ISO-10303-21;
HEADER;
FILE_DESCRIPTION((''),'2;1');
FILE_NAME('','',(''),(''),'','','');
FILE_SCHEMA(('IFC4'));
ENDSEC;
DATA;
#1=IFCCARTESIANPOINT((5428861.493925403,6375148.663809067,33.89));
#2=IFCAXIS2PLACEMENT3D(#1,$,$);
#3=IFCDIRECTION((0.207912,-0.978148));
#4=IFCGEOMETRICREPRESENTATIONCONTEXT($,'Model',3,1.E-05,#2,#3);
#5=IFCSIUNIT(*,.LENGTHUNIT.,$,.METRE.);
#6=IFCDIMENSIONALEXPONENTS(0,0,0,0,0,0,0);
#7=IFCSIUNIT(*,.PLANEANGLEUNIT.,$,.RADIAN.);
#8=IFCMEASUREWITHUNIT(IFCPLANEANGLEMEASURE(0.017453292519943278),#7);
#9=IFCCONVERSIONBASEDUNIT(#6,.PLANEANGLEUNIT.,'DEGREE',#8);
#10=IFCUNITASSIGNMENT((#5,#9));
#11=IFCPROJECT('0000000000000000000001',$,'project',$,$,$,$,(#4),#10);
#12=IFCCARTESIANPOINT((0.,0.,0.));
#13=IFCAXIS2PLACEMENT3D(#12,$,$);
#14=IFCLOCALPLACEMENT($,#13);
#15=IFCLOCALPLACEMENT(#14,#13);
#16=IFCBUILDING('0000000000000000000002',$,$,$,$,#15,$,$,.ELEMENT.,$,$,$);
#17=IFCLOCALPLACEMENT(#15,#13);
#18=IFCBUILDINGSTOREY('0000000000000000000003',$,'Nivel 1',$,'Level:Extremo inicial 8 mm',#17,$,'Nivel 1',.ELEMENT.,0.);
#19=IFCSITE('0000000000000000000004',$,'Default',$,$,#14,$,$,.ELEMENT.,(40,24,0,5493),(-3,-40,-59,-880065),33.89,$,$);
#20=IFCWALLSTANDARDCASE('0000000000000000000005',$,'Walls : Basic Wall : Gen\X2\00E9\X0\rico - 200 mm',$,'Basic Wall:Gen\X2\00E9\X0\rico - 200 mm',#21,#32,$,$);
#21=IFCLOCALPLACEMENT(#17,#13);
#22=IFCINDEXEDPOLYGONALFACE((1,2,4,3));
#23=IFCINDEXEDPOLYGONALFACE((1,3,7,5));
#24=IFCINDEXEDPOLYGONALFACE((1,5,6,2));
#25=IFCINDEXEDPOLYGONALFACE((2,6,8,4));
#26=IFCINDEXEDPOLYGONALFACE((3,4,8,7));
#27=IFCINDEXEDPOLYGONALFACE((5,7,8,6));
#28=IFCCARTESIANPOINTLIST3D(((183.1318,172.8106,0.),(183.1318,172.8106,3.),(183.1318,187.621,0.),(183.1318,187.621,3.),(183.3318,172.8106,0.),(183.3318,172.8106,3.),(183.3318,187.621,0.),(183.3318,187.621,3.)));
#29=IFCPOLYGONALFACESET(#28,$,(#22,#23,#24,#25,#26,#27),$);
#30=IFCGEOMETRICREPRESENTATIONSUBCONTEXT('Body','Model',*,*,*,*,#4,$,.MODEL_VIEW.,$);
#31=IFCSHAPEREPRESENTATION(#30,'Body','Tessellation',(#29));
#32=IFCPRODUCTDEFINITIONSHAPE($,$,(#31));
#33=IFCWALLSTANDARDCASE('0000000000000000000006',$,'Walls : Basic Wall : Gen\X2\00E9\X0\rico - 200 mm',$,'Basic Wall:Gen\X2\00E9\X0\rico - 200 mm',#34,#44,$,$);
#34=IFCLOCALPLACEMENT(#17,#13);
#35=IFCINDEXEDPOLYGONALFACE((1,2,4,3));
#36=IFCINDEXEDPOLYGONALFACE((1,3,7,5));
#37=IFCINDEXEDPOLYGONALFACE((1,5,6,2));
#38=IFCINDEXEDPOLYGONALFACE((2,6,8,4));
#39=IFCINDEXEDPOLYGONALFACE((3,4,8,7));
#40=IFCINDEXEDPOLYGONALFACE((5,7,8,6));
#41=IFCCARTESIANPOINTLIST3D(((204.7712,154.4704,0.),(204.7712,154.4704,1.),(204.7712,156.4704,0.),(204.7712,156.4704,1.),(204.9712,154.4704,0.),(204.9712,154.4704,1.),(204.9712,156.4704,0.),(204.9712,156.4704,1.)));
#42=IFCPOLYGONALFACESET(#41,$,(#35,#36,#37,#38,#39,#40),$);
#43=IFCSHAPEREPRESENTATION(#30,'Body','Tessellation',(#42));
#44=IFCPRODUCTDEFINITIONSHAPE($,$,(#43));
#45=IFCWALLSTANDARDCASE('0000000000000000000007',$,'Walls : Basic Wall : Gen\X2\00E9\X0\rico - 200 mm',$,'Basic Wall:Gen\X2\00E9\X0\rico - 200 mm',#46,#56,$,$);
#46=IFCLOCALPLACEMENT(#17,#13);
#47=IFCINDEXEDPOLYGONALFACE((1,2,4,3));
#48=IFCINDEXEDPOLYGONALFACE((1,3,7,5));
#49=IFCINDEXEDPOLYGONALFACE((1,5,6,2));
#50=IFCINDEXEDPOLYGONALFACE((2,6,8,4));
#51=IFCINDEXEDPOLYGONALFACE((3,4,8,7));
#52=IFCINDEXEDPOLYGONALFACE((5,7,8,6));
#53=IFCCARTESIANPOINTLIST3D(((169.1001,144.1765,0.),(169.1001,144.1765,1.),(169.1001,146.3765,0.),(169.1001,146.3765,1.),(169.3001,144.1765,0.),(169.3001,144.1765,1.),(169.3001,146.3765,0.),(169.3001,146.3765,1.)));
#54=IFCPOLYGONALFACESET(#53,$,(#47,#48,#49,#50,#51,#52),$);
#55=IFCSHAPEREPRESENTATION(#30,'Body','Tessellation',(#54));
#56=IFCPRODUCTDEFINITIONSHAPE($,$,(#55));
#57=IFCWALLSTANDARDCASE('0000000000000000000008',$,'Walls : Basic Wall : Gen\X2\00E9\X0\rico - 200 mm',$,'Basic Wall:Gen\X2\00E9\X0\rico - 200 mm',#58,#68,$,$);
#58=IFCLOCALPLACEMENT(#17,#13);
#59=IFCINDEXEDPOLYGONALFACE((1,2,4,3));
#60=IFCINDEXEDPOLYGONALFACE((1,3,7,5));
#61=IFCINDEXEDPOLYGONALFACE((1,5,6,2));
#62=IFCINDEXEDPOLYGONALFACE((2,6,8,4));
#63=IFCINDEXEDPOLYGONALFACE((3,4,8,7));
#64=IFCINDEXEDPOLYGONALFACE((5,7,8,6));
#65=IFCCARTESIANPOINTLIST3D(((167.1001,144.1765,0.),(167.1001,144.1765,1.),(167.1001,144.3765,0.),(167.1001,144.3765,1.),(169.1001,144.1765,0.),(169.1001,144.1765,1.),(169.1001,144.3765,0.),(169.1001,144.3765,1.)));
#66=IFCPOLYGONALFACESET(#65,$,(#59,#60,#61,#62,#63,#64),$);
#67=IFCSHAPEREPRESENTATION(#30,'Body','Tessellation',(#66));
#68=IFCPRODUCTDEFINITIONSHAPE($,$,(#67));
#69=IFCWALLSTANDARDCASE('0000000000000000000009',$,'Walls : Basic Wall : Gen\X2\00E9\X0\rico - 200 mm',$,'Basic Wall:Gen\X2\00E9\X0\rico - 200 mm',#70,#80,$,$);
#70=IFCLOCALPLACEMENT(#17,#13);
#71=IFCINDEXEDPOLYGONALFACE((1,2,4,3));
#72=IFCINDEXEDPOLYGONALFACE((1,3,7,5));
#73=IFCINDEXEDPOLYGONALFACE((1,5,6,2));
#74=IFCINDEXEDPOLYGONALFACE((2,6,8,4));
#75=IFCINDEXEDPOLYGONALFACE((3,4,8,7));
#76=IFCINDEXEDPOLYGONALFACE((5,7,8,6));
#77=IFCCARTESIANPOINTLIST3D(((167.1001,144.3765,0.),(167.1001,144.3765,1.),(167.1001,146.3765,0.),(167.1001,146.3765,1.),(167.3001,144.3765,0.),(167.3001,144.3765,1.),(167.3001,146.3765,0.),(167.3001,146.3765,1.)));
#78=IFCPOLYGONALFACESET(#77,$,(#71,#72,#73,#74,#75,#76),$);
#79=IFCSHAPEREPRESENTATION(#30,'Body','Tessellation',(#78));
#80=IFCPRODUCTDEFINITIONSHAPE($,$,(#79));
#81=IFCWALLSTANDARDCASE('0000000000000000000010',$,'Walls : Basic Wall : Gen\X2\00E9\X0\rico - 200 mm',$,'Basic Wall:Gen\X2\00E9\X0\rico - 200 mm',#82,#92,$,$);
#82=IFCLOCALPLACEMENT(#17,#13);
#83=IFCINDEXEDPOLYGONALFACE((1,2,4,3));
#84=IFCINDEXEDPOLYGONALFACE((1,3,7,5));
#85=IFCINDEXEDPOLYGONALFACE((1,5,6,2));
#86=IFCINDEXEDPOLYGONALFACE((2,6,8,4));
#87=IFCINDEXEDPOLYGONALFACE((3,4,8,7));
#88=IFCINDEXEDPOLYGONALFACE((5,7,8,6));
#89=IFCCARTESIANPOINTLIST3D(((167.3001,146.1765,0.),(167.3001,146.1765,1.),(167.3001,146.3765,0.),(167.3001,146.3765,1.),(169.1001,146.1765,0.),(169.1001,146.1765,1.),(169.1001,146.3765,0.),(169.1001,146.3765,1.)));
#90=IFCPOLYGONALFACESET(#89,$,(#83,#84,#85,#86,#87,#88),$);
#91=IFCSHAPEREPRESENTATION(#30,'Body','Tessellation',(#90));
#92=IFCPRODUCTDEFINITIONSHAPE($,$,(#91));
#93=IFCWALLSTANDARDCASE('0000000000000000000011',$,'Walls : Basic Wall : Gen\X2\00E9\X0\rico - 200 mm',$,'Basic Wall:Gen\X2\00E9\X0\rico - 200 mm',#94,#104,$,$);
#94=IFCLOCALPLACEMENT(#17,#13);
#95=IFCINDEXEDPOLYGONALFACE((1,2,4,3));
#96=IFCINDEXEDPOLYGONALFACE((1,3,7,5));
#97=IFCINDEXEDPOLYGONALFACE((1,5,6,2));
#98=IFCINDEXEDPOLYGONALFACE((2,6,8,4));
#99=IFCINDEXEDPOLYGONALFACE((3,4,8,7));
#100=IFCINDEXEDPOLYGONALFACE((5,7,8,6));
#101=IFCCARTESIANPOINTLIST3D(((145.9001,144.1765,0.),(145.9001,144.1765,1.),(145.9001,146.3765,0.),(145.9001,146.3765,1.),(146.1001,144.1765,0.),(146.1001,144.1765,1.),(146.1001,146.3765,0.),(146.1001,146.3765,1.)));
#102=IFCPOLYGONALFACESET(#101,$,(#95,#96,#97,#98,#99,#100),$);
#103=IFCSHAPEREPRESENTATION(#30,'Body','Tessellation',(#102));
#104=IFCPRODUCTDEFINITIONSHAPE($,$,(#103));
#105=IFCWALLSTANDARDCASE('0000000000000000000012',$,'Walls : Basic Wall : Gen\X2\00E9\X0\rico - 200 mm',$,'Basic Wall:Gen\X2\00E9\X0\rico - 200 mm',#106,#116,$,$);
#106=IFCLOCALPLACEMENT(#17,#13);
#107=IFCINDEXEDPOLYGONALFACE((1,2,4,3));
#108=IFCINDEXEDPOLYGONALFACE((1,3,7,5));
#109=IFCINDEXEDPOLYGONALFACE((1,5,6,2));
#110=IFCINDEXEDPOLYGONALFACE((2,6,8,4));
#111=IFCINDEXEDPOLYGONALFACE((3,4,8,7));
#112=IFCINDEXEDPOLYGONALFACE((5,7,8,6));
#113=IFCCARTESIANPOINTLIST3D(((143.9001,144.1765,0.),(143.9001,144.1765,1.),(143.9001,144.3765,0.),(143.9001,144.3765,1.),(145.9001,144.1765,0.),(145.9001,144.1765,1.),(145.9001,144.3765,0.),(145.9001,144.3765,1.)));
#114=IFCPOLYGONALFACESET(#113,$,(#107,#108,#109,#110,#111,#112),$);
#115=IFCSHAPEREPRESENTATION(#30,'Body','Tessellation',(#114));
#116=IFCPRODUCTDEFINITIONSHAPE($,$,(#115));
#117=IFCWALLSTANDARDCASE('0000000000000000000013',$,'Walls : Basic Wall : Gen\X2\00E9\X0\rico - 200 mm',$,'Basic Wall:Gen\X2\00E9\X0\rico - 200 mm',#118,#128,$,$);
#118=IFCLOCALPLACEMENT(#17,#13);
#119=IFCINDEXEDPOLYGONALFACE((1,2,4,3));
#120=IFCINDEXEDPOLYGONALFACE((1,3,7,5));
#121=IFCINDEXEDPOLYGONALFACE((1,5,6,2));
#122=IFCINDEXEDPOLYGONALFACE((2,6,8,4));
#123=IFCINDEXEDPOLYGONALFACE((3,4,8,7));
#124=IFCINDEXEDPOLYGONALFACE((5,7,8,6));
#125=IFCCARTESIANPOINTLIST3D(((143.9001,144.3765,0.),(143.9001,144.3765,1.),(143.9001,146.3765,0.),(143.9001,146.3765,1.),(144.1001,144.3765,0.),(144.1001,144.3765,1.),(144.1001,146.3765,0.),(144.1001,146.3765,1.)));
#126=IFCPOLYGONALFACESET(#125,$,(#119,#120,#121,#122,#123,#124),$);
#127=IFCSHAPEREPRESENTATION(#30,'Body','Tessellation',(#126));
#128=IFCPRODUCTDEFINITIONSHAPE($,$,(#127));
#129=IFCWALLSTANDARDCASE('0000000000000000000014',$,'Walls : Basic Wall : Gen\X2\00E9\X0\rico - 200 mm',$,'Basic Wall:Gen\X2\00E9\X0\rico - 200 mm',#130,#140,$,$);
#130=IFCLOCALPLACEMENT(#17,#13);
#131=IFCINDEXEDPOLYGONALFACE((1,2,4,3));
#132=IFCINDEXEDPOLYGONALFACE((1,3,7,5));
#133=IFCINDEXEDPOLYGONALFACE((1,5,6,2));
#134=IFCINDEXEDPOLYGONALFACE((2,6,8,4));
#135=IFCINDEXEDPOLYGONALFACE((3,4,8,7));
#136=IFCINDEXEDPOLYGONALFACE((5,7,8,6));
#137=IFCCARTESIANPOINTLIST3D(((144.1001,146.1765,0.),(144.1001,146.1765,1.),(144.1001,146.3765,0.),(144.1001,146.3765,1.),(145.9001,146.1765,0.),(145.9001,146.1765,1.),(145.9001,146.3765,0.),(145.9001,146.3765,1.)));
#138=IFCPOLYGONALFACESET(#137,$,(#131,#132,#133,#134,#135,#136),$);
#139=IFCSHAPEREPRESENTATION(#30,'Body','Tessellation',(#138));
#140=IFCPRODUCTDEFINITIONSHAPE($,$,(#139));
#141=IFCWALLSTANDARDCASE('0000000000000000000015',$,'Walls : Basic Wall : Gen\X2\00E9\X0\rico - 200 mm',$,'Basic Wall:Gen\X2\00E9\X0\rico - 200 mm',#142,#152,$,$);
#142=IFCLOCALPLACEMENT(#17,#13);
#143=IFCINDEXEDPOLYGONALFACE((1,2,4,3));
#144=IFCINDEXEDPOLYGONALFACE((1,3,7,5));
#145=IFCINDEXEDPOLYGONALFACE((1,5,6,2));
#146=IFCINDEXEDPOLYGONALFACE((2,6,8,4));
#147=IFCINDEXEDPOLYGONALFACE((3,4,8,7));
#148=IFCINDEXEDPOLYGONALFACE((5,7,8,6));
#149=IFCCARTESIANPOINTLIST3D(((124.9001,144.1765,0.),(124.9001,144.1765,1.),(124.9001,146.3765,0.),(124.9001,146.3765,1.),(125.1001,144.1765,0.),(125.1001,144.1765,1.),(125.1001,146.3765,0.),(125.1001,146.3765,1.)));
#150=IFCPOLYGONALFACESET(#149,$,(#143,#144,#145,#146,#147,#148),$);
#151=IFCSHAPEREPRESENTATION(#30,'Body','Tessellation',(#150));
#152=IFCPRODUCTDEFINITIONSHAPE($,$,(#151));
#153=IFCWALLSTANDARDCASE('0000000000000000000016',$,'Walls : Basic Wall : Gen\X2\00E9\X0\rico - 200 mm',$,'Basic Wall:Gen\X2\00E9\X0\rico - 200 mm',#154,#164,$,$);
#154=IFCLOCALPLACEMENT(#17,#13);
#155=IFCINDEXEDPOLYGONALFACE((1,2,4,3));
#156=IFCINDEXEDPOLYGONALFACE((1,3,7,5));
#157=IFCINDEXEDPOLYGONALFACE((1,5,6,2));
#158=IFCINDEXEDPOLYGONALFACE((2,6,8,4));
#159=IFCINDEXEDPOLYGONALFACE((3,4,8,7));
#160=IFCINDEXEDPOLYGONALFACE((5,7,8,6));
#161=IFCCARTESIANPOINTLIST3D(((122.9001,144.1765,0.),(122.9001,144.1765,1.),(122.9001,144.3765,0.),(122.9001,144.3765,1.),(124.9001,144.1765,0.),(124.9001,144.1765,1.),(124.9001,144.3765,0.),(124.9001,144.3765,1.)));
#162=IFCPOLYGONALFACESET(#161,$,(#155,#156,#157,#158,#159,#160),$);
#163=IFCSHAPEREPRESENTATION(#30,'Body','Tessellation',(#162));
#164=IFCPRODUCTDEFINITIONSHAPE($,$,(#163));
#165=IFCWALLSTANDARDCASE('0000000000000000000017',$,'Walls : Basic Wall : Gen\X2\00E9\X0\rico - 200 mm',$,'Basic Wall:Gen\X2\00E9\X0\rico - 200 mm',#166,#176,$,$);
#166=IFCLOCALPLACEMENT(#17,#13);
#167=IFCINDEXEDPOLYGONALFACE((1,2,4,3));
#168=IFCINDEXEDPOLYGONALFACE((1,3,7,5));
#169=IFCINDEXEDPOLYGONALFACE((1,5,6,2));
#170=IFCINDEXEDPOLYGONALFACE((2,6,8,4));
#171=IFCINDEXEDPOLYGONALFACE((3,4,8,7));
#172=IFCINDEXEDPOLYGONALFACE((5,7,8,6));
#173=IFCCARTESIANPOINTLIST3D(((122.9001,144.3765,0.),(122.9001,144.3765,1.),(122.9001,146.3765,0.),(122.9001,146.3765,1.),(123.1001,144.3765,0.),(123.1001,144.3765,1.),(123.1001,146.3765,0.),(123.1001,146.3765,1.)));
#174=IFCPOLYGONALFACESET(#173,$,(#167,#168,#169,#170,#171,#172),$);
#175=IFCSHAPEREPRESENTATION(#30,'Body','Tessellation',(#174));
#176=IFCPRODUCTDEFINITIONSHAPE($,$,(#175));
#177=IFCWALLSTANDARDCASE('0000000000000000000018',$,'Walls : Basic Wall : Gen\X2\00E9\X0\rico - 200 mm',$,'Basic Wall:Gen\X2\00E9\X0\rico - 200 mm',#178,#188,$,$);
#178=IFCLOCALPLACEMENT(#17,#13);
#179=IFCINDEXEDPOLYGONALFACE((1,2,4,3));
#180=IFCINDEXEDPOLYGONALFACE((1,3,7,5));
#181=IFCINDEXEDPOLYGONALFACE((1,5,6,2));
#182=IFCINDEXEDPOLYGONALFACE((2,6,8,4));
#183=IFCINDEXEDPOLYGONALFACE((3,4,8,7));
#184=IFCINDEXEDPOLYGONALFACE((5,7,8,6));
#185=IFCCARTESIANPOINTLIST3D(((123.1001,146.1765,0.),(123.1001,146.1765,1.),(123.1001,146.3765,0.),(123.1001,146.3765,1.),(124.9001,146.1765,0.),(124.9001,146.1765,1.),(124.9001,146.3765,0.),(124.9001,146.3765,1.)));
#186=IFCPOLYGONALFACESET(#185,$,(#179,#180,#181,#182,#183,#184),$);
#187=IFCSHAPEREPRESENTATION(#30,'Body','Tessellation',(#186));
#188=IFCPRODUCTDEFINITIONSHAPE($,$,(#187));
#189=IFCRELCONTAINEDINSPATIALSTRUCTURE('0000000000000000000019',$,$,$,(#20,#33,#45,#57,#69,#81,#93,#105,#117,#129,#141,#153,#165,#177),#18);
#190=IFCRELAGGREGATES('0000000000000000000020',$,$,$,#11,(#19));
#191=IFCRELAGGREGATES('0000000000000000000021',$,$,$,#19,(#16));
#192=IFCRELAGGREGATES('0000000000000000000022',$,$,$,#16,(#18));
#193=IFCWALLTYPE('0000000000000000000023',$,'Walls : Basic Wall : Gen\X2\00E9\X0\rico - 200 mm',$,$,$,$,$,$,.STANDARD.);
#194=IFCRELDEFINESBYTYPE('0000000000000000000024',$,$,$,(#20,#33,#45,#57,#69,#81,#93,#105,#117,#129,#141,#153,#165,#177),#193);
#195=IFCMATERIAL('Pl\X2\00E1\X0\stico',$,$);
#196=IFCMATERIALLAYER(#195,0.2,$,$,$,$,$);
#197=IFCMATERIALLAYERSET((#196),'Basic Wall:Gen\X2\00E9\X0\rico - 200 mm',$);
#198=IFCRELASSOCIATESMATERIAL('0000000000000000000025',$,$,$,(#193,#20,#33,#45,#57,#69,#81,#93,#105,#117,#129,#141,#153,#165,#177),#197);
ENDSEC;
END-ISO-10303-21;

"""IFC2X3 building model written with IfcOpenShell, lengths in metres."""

from ifc_helpers import new_model, entity, si_unit, converted_unit, direction, frame, frame_2d, origin, place, context, subcontext, project, spatial, rectangle, extrude, material, layer, layer_set, layer_usage, type_object, element, save


model = new_model("IFC2X3")

# Units and contexts
model_context = context("Model", 3, precision=1e-05, world=frame((5428861.493925403, 6375148.663809067, 33.89)), true_north=direction((0.207912, -0.978148)))
body_context = subcontext(model_context, "Body", "Model", "MODEL_VIEW")
ifc_project = project(units=[si_unit("LENGTHUNIT", "METRE"), converted_unit("PLANEANGLEUNIT", "DEGREE", entity("IfcPlaneAngleMeasure", 0.017453292519943278), si_unit("PLANEANGLEUNIT", "RADIAN"), dimensions=[0, 0, 0, 0, 0, 0, 0])], contexts=[model_context])

# Site, building, storey
site_placement = place(None, origin())
site = spatial("IfcSite", under=ifc_project, at=site_placement, Name="Default", CompositionType="ELEMENT", RefLatitude=(40, 24, 0, 5493), RefLongitude=(-3, -40, -59, -880065), RefElevation=33.89)
building_placement = place(site_placement, origin())
building = spatial("IfcBuilding", under=site, at=building_placement, CompositionType="ELEMENT")
storey_placement = place(building_placement, origin())
storey = spatial("IfcBuildingStorey", under=building, at=storey_placement, Name="Nivel 1", ObjectType="Level:Extremo inicial 8 mm", LongName="Nivel 1", CompositionType="ELEMENT", Elevation=0.0)

# Walls
ifc_material_1 = material(Name="Plástico")
ifc_layer_1 = layer(ifc_material_1, 0.2)
ifc_layer_set_1 = layer_set([ifc_layer_1], Name="Basic Wall:Genérico - 200 mm")
wall_type = type_object("IfcWallType", Name="Walls : Basic Wall : Genérico - 200 mm", PredefinedType="STANDARD", material=ifc_layer_set_1)
ifc_layer_usage_1 = layer_usage(ifc_layer_set_1, "AXIS2", "NEGATIVE", 0.1)
wall_1_placement = place(storey_placement, frame((183.2318, 172.8106, 0.0), z_axis=(0.0, 0.0, 1.0), x_axis=(0.0, 1.0, 0.0)))
element("IfcWallStandardCase", 1, at=wall_1_placement, inside=storey, type_object=wall_type, material=ifc_layer_usage_1, Name="Walls : Basic Wall : Genérico - 200 mm", ObjectType="Basic Wall:Genérico - 200 mm", context=body_context, shape_type="SweptSolid", body=[
    extrude(rectangle(XDim=14.8104, YDim=0.2, at=frame_2d((7.4052, 0.0), x_axis=(-1.0, 0.0))), origin(), (0.0, 0.0, 1.0), 3.0),
])
ifc_layer_usage_2 = layer_usage(ifc_layer_set_1, "AXIS2", "NEGATIVE", 0.1)
wall_2_placement = place(storey_placement, frame((204.8712, 154.4704, 0.0), z_axis=(0.0, 0.0, 1.0), x_axis=(0.0, 1.0, 0.0)))
element("IfcWallStandardCase", 2, at=wall_2_placement, inside=storey, type_object=wall_type, material=ifc_layer_usage_2, Name="Walls : Basic Wall : Genérico - 200 mm", ObjectType="Basic Wall:Genérico - 200 mm", context=body_context, shape_type="SweptSolid", body=[
    extrude(rectangle(XDim=2.0, YDim=0.2, at=frame_2d((1.0, 0.0), x_axis=(-1.0, 0.0))), origin(), (0.0, 0.0, 1.0), 1.0),
])
ifc_layer_usage_3 = layer_usage(ifc_layer_set_1, "AXIS2", "NEGATIVE", 0.1)
wall_3_placement = place(storey_placement, frame((169.2001, 146.3765, 0.0), z_axis=(0.0, 0.0, 1.0), x_axis=(0.0, -1.0, 0.0)))
element("IfcWallStandardCase", 3, at=wall_3_placement, inside=storey, type_object=wall_type, material=ifc_layer_usage_3, Name="Walls : Basic Wall : Genérico - 200 mm", ObjectType="Basic Wall:Genérico - 200 mm", context=body_context, shape_type="SweptSolid", body=[
    extrude(rectangle(XDim=2.2, YDim=0.2, at=frame_2d((1.1, 0.0), x_axis=(-1.0, 0.0))), origin(), (0.0, 0.0, 1.0), 1.0),
])
ifc_layer_usage_4 = layer_usage(ifc_layer_set_1, "AXIS2", "NEGATIVE", 0.1)
wall_4_placement = place(storey_placement, frame((169.1001, 144.2765, 0.0), z_axis=(0.0, 0.0, 1.0), x_axis=(-1.0, 0.0, 0.0)))
element("IfcWallStandardCase", 4, at=wall_4_placement, inside=storey, type_object=wall_type, material=ifc_layer_usage_4, Name="Walls : Basic Wall : Genérico - 200 mm", ObjectType="Basic Wall:Genérico - 200 mm", context=body_context, shape_type="SweptSolid", body=[
    extrude(rectangle(XDim=2.0, YDim=0.2, at=frame_2d((1.0, 0.0), x_axis=(-1.0, 0.0))), origin(), (0.0, 0.0, 1.0), 1.0),
])
ifc_layer_usage_5 = layer_usage(ifc_layer_set_1, "AXIS2", "NEGATIVE", 0.1)
wall_5_placement = place(storey_placement, frame((167.2001, 144.3765, 0.0), z_axis=(0.0, 0.0, 1.0), x_axis=(0.0, 1.0, 0.0)))
element("IfcWallStandardCase", 5, at=wall_5_placement, inside=storey, type_object=wall_type, material=ifc_layer_usage_5, Name="Walls : Basic Wall : Genérico - 200 mm", ObjectType="Basic Wall:Genérico - 200 mm", context=body_context, shape_type="SweptSolid", body=[
    extrude(rectangle(XDim=2.0, YDim=0.2, at=frame_2d((1.0, 0.0), x_axis=(-1.0, 0.0))), origin(), (0.0, 0.0, 1.0), 1.0),
])
ifc_layer_usage_6 = layer_usage(ifc_layer_set_1, "AXIS2", "NEGATIVE", 0.1)
wall_6_placement = place(storey_placement, frame((167.3001, 146.2765, 0.0)))
element("IfcWallStandardCase", 6, at=wall_6_placement, inside=storey, type_object=wall_type, material=ifc_layer_usage_6, Name="Walls : Basic Wall : Genérico - 200 mm", ObjectType="Basic Wall:Genérico - 200 mm", context=body_context, shape_type="SweptSolid", body=[
    extrude(rectangle(XDim=1.8, YDim=0.2, at=frame_2d((0.9, 0.0), x_axis=(-1.0, 0.0))), origin(), (0.0, 0.0, 1.0), 1.0),
])
ifc_layer_usage_7 = layer_usage(ifc_layer_set_1, "AXIS2", "NEGATIVE", 0.1)
wall_7_placement = place(storey_placement, frame((146.0001, 146.3765, 0.0), z_axis=(0.0, 0.0, 1.0), x_axis=(0.0, -1.0, 0.0)))
element("IfcWallStandardCase", 7, at=wall_7_placement, inside=storey, type_object=wall_type, material=ifc_layer_usage_7, Name="Walls : Basic Wall : Genérico - 200 mm", ObjectType="Basic Wall:Genérico - 200 mm", context=body_context, shape_type="SweptSolid", body=[
    extrude(rectangle(XDim=2.2, YDim=0.2, at=frame_2d((1.1, 0.0), x_axis=(-1.0, 0.0))), origin(), (0.0, 0.0, 1.0), 1.0),
])
ifc_layer_usage_8 = layer_usage(ifc_layer_set_1, "AXIS2", "NEGATIVE", 0.1)
wall_8_placement = place(storey_placement, frame((145.9001, 144.2765, 0.0), z_axis=(0.0, 0.0, 1.0), x_axis=(-1.0, 0.0, 0.0)))
element("IfcWallStandardCase", 8, at=wall_8_placement, inside=storey, type_object=wall_type, material=ifc_layer_usage_8, Name="Walls : Basic Wall : Genérico - 200 mm", ObjectType="Basic Wall:Genérico - 200 mm", context=body_context, shape_type="SweptSolid", body=[
    extrude(rectangle(XDim=2.0, YDim=0.2, at=frame_2d((1.0, 0.0), x_axis=(-1.0, 0.0))), origin(), (0.0, 0.0, 1.0), 1.0),
])
ifc_layer_usage_9 = layer_usage(ifc_layer_set_1, "AXIS2", "NEGATIVE", 0.1)
wall_9_placement = place(storey_placement, frame((144.0001, 144.3765, 0.0), z_axis=(0.0, 0.0, 1.0), x_axis=(0.0, 1.0, 0.0)))
element("IfcWallStandardCase", 9, at=wall_9_placement, inside=storey, type_object=wall_type, material=ifc_layer_usage_9, Name="Walls : Basic Wall : Genérico - 200 mm", ObjectType="Basic Wall:Genérico - 200 mm", context=body_context, shape_type="SweptSolid", body=[
    extrude(rectangle(XDim=2.0, YDim=0.2, at=frame_2d((1.0, 0.0), x_axis=(-1.0, 0.0))), origin(), (0.0, 0.0, 1.0), 1.0),
])
ifc_layer_usage_10 = layer_usage(ifc_layer_set_1, "AXIS2", "NEGATIVE", 0.1)
wall_10_placement = place(storey_placement, frame((144.1001, 146.2765, 0.0)))
element("IfcWallStandardCase", 10, at=wall_10_placement, inside=storey, type_object=wall_type, material=ifc_layer_usage_10, Name="Walls : Basic Wall : Genérico - 200 mm", ObjectType="Basic Wall:Genérico - 200 mm", context=body_context, shape_type="SweptSolid", body=[
    extrude(rectangle(XDim=1.8, YDim=0.2, at=frame_2d((0.9, 0.0), x_axis=(-1.0, 0.0))), origin(), (0.0, 0.0, 1.0), 1.0),
])
ifc_layer_usage_11 = layer_usage(ifc_layer_set_1, "AXIS2", "NEGATIVE", 0.1)
wall_11_placement = place(storey_placement, frame((125.0001, 146.3765, 0.0), z_axis=(0.0, 0.0, 1.0), x_axis=(0.0, -1.0, 0.0)))
element("IfcWallStandardCase", 11, at=wall_11_placement, inside=storey, type_object=wall_type, material=ifc_layer_usage_11, Name="Walls : Basic Wall : Genérico - 200 mm", ObjectType="Basic Wall:Genérico - 200 mm", context=body_context, shape_type="SweptSolid", body=[
    extrude(rectangle(XDim=2.2, YDim=0.2, at=frame_2d((1.1, 0.0), x_axis=(-1.0, 0.0))), origin(), (0.0, 0.0, 1.0), 1.0),
])
ifc_layer_usage_12 = layer_usage(ifc_layer_set_1, "AXIS2", "NEGATIVE", 0.1)
wall_12_placement = place(storey_placement, frame((124.9001, 144.2765, 0.0), z_axis=(0.0, 0.0, 1.0), x_axis=(-1.0, 0.0, 0.0)))
element("IfcWallStandardCase", 12, at=wall_12_placement, inside=storey, type_object=wall_type, material=ifc_layer_usage_12, Name="Walls : Basic Wall : Genérico - 200 mm", ObjectType="Basic Wall:Genérico - 200 mm", context=body_context, shape_type="SweptSolid", body=[
    extrude(rectangle(XDim=2.0, YDim=0.2, at=frame_2d((1.0, 0.0), x_axis=(-1.0, 0.0))), origin(), (0.0, 0.0, 1.0), 1.0),
])
ifc_layer_usage_13 = layer_usage(ifc_layer_set_1, "AXIS2", "NEGATIVE", 0.1)
wall_13_placement = place(storey_placement, frame((123.0001, 144.3765, 0.0), z_axis=(0.0, 0.0, 1.0), x_axis=(0.0, 1.0, 0.0)))
element("IfcWallStandardCase", 13, at=wall_13_placement, inside=storey, type_object=wall_type, material=ifc_layer_usage_13, Name="Walls : Basic Wall : Genérico - 200 mm", ObjectType="Basic Wall:Genérico - 200 mm", context=body_context, shape_type="SweptSolid", body=[
    extrude(rectangle(XDim=2.0, YDim=0.2, at=frame_2d((1.0, 0.0), x_axis=(-1.0, 0.0))), origin(), (0.0, 0.0, 1.0), 1.0),
])
ifc_layer_usage_14 = layer_usage(ifc_layer_set_1, "AXIS2", "NEGATIVE", 0.1)
wall_14_placement = place(storey_placement, frame((123.1001, 146.2765, 0.0)))
element("IfcWallStandardCase", 14, at=wall_14_placement, inside=storey, type_object=wall_type, material=ifc_layer_usage_14, Name="Walls : Basic Wall : Genérico - 200 mm", ObjectType="Basic Wall:Genérico - 200 mm", context=body_context, shape_type="SweptSolid", body=[
    extrude(rectangle(XDim=1.8, YDim=0.2, at=frame_2d((0.9, 0.0), x_axis=(-1.0, 0.0))), origin(), (0.0, 0.0, 1.0), 1.0),
])

save(model, "model.ifc")
